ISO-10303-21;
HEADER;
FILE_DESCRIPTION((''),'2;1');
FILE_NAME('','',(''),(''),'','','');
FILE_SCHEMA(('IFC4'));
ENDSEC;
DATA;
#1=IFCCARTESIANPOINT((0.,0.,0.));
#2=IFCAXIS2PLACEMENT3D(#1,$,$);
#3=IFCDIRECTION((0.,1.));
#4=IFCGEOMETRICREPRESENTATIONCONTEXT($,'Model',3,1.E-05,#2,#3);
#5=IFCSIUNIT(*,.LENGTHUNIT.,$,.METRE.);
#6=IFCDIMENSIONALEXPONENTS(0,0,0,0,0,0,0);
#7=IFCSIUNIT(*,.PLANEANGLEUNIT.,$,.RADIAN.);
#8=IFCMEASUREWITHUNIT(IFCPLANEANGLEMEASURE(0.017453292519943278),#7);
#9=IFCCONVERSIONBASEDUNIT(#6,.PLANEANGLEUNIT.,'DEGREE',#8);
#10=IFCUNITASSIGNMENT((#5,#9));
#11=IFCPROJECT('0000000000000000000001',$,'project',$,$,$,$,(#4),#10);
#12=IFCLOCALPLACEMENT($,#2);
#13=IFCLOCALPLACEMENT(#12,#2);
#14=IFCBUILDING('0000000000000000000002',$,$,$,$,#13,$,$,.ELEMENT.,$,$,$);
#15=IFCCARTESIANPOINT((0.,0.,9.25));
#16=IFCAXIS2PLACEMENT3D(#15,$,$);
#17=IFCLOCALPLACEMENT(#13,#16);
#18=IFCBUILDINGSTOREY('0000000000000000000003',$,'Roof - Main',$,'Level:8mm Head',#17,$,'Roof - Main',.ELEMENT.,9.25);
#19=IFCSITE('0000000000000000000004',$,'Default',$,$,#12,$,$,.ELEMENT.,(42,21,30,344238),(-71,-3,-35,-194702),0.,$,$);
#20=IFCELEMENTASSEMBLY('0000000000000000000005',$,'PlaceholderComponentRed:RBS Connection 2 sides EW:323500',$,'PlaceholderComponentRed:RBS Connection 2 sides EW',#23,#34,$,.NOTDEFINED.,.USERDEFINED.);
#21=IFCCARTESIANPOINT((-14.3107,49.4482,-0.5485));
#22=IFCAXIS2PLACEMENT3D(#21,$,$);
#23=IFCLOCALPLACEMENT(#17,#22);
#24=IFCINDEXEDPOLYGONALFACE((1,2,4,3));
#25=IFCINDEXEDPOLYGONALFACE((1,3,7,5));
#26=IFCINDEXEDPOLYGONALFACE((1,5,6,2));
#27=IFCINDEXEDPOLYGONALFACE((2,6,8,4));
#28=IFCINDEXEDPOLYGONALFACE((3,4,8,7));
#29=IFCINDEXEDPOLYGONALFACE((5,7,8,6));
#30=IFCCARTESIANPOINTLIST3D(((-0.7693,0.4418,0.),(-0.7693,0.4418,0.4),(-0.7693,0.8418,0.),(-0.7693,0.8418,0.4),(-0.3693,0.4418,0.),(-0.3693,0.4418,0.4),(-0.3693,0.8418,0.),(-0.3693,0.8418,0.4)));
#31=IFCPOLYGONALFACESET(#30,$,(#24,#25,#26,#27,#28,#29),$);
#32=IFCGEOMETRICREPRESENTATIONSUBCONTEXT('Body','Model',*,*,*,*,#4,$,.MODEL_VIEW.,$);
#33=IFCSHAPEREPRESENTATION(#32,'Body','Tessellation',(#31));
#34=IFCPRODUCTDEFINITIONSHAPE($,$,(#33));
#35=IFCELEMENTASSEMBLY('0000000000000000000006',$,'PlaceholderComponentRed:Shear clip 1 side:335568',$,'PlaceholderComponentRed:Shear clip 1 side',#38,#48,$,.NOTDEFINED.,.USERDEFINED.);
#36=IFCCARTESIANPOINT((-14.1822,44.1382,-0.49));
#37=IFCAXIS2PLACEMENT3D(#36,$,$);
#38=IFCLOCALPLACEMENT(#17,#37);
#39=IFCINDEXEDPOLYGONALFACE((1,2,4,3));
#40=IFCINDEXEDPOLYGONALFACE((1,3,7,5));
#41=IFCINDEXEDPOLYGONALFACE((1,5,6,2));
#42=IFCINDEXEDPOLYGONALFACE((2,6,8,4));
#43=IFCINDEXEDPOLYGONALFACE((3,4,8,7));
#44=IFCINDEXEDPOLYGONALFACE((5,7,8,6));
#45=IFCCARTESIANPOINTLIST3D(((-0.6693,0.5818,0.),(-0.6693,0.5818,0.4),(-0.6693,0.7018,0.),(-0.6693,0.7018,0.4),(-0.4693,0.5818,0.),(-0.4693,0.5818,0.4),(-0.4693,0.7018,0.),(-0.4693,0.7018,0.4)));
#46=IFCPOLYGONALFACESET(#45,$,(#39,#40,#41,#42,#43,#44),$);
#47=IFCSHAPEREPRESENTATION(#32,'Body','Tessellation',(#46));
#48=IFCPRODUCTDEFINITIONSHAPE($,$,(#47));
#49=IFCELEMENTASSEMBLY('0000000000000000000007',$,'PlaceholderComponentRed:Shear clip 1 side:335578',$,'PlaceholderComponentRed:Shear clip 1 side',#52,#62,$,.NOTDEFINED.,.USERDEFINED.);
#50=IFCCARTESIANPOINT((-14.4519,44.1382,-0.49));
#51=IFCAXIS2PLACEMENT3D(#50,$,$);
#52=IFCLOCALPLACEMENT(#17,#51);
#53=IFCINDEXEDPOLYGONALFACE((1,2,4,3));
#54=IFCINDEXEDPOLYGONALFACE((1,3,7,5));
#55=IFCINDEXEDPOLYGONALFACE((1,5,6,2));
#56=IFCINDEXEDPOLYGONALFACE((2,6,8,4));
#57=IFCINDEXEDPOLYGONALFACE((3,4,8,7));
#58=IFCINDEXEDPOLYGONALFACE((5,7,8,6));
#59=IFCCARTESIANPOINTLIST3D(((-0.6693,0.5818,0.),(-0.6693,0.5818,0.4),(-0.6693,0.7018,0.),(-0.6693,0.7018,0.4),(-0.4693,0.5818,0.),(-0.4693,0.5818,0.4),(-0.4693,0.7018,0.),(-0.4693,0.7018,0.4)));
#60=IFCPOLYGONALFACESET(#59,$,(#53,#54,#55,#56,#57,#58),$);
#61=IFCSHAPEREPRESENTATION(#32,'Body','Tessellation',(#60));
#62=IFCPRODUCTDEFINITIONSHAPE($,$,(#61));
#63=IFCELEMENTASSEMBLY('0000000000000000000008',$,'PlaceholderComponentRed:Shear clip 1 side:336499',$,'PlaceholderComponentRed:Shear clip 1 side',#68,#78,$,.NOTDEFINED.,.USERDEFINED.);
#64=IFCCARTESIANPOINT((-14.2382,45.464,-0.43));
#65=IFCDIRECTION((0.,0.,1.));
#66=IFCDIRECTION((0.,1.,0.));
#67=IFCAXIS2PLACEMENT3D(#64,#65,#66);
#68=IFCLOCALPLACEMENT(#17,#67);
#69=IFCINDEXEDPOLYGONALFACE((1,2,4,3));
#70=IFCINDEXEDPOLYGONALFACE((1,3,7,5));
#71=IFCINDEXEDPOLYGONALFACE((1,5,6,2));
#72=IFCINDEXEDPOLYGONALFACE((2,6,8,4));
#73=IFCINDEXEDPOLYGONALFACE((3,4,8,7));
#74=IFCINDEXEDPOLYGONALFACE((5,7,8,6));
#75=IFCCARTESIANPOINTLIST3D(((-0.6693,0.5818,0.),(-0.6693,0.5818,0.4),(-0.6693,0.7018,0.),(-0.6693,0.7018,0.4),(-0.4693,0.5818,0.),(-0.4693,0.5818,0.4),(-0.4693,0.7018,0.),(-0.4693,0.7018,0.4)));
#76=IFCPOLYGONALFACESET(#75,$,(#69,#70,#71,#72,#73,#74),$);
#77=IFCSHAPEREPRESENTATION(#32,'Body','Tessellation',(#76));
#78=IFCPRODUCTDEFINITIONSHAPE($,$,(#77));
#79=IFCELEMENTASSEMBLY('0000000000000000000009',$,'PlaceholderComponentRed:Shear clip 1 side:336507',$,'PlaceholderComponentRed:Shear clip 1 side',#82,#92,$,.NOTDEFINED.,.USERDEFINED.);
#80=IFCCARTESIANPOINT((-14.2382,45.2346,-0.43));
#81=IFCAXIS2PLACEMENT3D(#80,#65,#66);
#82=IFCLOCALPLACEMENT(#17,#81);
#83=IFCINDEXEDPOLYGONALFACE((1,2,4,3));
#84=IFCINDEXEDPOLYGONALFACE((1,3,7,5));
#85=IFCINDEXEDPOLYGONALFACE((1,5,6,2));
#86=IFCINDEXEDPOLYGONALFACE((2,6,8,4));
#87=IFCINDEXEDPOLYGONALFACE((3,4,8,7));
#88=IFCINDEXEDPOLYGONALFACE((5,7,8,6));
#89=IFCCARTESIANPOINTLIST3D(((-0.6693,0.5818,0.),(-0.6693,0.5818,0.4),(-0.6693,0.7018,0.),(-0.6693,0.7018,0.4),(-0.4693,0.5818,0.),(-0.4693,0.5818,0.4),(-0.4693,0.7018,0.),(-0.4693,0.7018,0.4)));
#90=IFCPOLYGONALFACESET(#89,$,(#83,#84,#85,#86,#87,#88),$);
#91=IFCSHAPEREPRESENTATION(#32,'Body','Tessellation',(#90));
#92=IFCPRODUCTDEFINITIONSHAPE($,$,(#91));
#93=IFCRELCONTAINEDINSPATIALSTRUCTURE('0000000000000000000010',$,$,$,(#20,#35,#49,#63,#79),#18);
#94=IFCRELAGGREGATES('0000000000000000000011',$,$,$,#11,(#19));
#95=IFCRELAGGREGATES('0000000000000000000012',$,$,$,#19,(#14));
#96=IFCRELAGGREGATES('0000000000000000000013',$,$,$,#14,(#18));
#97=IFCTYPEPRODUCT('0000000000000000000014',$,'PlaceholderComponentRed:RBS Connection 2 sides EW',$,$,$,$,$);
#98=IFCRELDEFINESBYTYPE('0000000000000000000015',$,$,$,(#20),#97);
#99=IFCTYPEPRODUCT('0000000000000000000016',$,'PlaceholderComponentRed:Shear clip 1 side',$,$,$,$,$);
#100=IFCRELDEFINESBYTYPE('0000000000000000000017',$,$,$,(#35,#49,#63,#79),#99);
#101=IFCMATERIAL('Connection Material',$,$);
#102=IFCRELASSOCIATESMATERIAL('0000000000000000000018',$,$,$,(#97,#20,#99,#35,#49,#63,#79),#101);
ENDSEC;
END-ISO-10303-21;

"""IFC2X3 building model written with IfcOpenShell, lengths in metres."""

from ifc_helpers import new_model, entity, si_unit, converted_unit, direction, frame, frame_2d, origin, place, context, subcontext, project, spatial, rectangle, extrude, source, transform, mapped, material, type_object, type_shapes, element, save


model = new_model("IFC2X3")

# Units and contexts
model_context = context("Model", 3, precision=1e-05, world=origin(), true_north=direction((0.0, 1.0)))
body_context = subcontext(model_context, "Body", "Model", "MODEL_VIEW")
ifc_project = project(units=[si_unit("LENGTHUNIT", "METRE"), converted_unit("PLANEANGLEUNIT", "DEGREE", entity("IfcPlaneAngleMeasure", 0.017453292519943278), si_unit("PLANEANGLEUNIT", "RADIAN"), dimensions=[0, 0, 0, 0, 0, 0, 0])], contexts=[model_context])

# Site, building, storey
site_placement = place(None, origin())
site = spatial("IfcSite", under=ifc_project, at=site_placement, Name="Default", CompositionType="ELEMENT", RefLatitude=(42, 21, 30, 344238), RefLongitude=(-71, -3, -35, -194702), RefElevation=0.0)
building_placement = place(site_placement, origin())
building = spatial("IfcBuilding", under=site, at=building_placement, CompositionType="ELEMENT")
storey_placement = place(building_placement, frame((0.0, 0.0, 9.25)))
storey = spatial("IfcBuildingStorey", under=building, at=storey_placement, Name="Roof - Main", ObjectType="Level:8mm Head", LongName="Roof - Main", CompositionType="ELEMENT", Elevation=9.25)

# Element assemblies
ifc_material_1 = material(Name="Connection Material")
type_product_1 = type_object("IfcTypeProduct", Name="PlaceholderComponentRed:RBS Connection 2 sides EW", material=ifc_material_1)
shared_shape_1 = source(origin(), body_context, "Body", "SweptSolid", [
    extrude(rectangle(XDim=0.4, YDim=0.4, at=frame_2d((0.0, 0.0), x_axis=(1.0, 0.0))), frame((-0.5693, 0.6418, 0.0), z_axis=(0.0, 0.0, 1.0), x_axis=(0.0, 1.0, 0.0)), (0.0, 0.0, 1.0), 0.4),
])
type_shapes(type_product_1, [shared_shape_1])
assembly_1_placement = place(storey_placement, frame((-14.3107, 49.4482, -0.5485)))
element("IfcElementAssembly", 1, at=assembly_1_placement, inside=storey, type_object=type_product_1, material=ifc_material_1, Name="PlaceholderComponentRed:RBS Connection 2 sides EW:323500", ObjectType="PlaceholderComponentRed:RBS Connection 2 sides EW", AssemblyPlace="NOTDEFINED", PredefinedType="USERDEFINED", context=body_context, shape_type="MappedRepresentation", body=[
    mapped(shared_shape_1, transform((0.0, 0.0, 0.0), scale=1.0)),
])
type_product_2 = type_object("IfcTypeProduct", Name="PlaceholderComponentRed:Shear clip 1 side", material=ifc_material_1)
shared_shape_2 = source(origin(), body_context, "Body", "SweptSolid", [
    extrude(rectangle(XDim=0.12, YDim=0.2, at=frame_2d((0.0, 0.0), x_axis=(1.0, 0.0))), frame((-0.5693, 0.6418, 0.0), z_axis=(0.0, 0.0, 1.0), x_axis=(0.0, 1.0, 0.0)), (0.0, 0.0, 1.0), 0.4),
])
type_shapes(type_product_2, [shared_shape_2])
for number, where, name in (
    (2, (-14.1822, 44.1382, -0.49), "PlaceholderComponentRed:Shear clip 1 side:335568"),
    (3, (-14.4519, 44.1382, -0.49), "PlaceholderComponentRed:Shear clip 1 side:335578"),
):
    element("IfcElementAssembly", number, at=place(storey_placement, frame(where)), inside=storey, type_object=type_product_2, material=ifc_material_1, Name=name, ObjectType="PlaceholderComponentRed:Shear clip 1 side", AssemblyPlace="NOTDEFINED", PredefinedType="USERDEFINED", context=body_context, shape_type="MappedRepresentation", body=[
        mapped(shared_shape_2, transform((0.0, 0.0, 0.0), scale=1.0)),
    ])
for number, where, z_axis, x_axis, name in (
    (4, (-14.2382, 45.464, -0.43), (0.0, 0.0, 1.0), (0.0, 1.0, 0.0), "PlaceholderComponentRed:Shear clip 1 side:336499"),
    (5, (-14.2382, 45.2346, -0.43), (0.0, 0.0, 1.0), (0.0, 1.0, 0.0), "PlaceholderComponentRed:Shear clip 1 side:336507"),
):
    element("IfcElementAssembly", number, at=place(storey_placement, frame(where, z_axis=z_axis, x_axis=x_axis)), inside=storey, type_object=type_product_2, material=ifc_material_1, Name=name, ObjectType="PlaceholderComponentRed:Shear clip 1 side", AssemblyPlace="NOTDEFINED", PredefinedType="USERDEFINED", context=body_context, shape_type="MappedRepresentation", body=[
        mapped(shared_shape_2, transform((0.0, 0.0, 0.0), scale=1.0)),
    ])

save(model, "model.ifc")
